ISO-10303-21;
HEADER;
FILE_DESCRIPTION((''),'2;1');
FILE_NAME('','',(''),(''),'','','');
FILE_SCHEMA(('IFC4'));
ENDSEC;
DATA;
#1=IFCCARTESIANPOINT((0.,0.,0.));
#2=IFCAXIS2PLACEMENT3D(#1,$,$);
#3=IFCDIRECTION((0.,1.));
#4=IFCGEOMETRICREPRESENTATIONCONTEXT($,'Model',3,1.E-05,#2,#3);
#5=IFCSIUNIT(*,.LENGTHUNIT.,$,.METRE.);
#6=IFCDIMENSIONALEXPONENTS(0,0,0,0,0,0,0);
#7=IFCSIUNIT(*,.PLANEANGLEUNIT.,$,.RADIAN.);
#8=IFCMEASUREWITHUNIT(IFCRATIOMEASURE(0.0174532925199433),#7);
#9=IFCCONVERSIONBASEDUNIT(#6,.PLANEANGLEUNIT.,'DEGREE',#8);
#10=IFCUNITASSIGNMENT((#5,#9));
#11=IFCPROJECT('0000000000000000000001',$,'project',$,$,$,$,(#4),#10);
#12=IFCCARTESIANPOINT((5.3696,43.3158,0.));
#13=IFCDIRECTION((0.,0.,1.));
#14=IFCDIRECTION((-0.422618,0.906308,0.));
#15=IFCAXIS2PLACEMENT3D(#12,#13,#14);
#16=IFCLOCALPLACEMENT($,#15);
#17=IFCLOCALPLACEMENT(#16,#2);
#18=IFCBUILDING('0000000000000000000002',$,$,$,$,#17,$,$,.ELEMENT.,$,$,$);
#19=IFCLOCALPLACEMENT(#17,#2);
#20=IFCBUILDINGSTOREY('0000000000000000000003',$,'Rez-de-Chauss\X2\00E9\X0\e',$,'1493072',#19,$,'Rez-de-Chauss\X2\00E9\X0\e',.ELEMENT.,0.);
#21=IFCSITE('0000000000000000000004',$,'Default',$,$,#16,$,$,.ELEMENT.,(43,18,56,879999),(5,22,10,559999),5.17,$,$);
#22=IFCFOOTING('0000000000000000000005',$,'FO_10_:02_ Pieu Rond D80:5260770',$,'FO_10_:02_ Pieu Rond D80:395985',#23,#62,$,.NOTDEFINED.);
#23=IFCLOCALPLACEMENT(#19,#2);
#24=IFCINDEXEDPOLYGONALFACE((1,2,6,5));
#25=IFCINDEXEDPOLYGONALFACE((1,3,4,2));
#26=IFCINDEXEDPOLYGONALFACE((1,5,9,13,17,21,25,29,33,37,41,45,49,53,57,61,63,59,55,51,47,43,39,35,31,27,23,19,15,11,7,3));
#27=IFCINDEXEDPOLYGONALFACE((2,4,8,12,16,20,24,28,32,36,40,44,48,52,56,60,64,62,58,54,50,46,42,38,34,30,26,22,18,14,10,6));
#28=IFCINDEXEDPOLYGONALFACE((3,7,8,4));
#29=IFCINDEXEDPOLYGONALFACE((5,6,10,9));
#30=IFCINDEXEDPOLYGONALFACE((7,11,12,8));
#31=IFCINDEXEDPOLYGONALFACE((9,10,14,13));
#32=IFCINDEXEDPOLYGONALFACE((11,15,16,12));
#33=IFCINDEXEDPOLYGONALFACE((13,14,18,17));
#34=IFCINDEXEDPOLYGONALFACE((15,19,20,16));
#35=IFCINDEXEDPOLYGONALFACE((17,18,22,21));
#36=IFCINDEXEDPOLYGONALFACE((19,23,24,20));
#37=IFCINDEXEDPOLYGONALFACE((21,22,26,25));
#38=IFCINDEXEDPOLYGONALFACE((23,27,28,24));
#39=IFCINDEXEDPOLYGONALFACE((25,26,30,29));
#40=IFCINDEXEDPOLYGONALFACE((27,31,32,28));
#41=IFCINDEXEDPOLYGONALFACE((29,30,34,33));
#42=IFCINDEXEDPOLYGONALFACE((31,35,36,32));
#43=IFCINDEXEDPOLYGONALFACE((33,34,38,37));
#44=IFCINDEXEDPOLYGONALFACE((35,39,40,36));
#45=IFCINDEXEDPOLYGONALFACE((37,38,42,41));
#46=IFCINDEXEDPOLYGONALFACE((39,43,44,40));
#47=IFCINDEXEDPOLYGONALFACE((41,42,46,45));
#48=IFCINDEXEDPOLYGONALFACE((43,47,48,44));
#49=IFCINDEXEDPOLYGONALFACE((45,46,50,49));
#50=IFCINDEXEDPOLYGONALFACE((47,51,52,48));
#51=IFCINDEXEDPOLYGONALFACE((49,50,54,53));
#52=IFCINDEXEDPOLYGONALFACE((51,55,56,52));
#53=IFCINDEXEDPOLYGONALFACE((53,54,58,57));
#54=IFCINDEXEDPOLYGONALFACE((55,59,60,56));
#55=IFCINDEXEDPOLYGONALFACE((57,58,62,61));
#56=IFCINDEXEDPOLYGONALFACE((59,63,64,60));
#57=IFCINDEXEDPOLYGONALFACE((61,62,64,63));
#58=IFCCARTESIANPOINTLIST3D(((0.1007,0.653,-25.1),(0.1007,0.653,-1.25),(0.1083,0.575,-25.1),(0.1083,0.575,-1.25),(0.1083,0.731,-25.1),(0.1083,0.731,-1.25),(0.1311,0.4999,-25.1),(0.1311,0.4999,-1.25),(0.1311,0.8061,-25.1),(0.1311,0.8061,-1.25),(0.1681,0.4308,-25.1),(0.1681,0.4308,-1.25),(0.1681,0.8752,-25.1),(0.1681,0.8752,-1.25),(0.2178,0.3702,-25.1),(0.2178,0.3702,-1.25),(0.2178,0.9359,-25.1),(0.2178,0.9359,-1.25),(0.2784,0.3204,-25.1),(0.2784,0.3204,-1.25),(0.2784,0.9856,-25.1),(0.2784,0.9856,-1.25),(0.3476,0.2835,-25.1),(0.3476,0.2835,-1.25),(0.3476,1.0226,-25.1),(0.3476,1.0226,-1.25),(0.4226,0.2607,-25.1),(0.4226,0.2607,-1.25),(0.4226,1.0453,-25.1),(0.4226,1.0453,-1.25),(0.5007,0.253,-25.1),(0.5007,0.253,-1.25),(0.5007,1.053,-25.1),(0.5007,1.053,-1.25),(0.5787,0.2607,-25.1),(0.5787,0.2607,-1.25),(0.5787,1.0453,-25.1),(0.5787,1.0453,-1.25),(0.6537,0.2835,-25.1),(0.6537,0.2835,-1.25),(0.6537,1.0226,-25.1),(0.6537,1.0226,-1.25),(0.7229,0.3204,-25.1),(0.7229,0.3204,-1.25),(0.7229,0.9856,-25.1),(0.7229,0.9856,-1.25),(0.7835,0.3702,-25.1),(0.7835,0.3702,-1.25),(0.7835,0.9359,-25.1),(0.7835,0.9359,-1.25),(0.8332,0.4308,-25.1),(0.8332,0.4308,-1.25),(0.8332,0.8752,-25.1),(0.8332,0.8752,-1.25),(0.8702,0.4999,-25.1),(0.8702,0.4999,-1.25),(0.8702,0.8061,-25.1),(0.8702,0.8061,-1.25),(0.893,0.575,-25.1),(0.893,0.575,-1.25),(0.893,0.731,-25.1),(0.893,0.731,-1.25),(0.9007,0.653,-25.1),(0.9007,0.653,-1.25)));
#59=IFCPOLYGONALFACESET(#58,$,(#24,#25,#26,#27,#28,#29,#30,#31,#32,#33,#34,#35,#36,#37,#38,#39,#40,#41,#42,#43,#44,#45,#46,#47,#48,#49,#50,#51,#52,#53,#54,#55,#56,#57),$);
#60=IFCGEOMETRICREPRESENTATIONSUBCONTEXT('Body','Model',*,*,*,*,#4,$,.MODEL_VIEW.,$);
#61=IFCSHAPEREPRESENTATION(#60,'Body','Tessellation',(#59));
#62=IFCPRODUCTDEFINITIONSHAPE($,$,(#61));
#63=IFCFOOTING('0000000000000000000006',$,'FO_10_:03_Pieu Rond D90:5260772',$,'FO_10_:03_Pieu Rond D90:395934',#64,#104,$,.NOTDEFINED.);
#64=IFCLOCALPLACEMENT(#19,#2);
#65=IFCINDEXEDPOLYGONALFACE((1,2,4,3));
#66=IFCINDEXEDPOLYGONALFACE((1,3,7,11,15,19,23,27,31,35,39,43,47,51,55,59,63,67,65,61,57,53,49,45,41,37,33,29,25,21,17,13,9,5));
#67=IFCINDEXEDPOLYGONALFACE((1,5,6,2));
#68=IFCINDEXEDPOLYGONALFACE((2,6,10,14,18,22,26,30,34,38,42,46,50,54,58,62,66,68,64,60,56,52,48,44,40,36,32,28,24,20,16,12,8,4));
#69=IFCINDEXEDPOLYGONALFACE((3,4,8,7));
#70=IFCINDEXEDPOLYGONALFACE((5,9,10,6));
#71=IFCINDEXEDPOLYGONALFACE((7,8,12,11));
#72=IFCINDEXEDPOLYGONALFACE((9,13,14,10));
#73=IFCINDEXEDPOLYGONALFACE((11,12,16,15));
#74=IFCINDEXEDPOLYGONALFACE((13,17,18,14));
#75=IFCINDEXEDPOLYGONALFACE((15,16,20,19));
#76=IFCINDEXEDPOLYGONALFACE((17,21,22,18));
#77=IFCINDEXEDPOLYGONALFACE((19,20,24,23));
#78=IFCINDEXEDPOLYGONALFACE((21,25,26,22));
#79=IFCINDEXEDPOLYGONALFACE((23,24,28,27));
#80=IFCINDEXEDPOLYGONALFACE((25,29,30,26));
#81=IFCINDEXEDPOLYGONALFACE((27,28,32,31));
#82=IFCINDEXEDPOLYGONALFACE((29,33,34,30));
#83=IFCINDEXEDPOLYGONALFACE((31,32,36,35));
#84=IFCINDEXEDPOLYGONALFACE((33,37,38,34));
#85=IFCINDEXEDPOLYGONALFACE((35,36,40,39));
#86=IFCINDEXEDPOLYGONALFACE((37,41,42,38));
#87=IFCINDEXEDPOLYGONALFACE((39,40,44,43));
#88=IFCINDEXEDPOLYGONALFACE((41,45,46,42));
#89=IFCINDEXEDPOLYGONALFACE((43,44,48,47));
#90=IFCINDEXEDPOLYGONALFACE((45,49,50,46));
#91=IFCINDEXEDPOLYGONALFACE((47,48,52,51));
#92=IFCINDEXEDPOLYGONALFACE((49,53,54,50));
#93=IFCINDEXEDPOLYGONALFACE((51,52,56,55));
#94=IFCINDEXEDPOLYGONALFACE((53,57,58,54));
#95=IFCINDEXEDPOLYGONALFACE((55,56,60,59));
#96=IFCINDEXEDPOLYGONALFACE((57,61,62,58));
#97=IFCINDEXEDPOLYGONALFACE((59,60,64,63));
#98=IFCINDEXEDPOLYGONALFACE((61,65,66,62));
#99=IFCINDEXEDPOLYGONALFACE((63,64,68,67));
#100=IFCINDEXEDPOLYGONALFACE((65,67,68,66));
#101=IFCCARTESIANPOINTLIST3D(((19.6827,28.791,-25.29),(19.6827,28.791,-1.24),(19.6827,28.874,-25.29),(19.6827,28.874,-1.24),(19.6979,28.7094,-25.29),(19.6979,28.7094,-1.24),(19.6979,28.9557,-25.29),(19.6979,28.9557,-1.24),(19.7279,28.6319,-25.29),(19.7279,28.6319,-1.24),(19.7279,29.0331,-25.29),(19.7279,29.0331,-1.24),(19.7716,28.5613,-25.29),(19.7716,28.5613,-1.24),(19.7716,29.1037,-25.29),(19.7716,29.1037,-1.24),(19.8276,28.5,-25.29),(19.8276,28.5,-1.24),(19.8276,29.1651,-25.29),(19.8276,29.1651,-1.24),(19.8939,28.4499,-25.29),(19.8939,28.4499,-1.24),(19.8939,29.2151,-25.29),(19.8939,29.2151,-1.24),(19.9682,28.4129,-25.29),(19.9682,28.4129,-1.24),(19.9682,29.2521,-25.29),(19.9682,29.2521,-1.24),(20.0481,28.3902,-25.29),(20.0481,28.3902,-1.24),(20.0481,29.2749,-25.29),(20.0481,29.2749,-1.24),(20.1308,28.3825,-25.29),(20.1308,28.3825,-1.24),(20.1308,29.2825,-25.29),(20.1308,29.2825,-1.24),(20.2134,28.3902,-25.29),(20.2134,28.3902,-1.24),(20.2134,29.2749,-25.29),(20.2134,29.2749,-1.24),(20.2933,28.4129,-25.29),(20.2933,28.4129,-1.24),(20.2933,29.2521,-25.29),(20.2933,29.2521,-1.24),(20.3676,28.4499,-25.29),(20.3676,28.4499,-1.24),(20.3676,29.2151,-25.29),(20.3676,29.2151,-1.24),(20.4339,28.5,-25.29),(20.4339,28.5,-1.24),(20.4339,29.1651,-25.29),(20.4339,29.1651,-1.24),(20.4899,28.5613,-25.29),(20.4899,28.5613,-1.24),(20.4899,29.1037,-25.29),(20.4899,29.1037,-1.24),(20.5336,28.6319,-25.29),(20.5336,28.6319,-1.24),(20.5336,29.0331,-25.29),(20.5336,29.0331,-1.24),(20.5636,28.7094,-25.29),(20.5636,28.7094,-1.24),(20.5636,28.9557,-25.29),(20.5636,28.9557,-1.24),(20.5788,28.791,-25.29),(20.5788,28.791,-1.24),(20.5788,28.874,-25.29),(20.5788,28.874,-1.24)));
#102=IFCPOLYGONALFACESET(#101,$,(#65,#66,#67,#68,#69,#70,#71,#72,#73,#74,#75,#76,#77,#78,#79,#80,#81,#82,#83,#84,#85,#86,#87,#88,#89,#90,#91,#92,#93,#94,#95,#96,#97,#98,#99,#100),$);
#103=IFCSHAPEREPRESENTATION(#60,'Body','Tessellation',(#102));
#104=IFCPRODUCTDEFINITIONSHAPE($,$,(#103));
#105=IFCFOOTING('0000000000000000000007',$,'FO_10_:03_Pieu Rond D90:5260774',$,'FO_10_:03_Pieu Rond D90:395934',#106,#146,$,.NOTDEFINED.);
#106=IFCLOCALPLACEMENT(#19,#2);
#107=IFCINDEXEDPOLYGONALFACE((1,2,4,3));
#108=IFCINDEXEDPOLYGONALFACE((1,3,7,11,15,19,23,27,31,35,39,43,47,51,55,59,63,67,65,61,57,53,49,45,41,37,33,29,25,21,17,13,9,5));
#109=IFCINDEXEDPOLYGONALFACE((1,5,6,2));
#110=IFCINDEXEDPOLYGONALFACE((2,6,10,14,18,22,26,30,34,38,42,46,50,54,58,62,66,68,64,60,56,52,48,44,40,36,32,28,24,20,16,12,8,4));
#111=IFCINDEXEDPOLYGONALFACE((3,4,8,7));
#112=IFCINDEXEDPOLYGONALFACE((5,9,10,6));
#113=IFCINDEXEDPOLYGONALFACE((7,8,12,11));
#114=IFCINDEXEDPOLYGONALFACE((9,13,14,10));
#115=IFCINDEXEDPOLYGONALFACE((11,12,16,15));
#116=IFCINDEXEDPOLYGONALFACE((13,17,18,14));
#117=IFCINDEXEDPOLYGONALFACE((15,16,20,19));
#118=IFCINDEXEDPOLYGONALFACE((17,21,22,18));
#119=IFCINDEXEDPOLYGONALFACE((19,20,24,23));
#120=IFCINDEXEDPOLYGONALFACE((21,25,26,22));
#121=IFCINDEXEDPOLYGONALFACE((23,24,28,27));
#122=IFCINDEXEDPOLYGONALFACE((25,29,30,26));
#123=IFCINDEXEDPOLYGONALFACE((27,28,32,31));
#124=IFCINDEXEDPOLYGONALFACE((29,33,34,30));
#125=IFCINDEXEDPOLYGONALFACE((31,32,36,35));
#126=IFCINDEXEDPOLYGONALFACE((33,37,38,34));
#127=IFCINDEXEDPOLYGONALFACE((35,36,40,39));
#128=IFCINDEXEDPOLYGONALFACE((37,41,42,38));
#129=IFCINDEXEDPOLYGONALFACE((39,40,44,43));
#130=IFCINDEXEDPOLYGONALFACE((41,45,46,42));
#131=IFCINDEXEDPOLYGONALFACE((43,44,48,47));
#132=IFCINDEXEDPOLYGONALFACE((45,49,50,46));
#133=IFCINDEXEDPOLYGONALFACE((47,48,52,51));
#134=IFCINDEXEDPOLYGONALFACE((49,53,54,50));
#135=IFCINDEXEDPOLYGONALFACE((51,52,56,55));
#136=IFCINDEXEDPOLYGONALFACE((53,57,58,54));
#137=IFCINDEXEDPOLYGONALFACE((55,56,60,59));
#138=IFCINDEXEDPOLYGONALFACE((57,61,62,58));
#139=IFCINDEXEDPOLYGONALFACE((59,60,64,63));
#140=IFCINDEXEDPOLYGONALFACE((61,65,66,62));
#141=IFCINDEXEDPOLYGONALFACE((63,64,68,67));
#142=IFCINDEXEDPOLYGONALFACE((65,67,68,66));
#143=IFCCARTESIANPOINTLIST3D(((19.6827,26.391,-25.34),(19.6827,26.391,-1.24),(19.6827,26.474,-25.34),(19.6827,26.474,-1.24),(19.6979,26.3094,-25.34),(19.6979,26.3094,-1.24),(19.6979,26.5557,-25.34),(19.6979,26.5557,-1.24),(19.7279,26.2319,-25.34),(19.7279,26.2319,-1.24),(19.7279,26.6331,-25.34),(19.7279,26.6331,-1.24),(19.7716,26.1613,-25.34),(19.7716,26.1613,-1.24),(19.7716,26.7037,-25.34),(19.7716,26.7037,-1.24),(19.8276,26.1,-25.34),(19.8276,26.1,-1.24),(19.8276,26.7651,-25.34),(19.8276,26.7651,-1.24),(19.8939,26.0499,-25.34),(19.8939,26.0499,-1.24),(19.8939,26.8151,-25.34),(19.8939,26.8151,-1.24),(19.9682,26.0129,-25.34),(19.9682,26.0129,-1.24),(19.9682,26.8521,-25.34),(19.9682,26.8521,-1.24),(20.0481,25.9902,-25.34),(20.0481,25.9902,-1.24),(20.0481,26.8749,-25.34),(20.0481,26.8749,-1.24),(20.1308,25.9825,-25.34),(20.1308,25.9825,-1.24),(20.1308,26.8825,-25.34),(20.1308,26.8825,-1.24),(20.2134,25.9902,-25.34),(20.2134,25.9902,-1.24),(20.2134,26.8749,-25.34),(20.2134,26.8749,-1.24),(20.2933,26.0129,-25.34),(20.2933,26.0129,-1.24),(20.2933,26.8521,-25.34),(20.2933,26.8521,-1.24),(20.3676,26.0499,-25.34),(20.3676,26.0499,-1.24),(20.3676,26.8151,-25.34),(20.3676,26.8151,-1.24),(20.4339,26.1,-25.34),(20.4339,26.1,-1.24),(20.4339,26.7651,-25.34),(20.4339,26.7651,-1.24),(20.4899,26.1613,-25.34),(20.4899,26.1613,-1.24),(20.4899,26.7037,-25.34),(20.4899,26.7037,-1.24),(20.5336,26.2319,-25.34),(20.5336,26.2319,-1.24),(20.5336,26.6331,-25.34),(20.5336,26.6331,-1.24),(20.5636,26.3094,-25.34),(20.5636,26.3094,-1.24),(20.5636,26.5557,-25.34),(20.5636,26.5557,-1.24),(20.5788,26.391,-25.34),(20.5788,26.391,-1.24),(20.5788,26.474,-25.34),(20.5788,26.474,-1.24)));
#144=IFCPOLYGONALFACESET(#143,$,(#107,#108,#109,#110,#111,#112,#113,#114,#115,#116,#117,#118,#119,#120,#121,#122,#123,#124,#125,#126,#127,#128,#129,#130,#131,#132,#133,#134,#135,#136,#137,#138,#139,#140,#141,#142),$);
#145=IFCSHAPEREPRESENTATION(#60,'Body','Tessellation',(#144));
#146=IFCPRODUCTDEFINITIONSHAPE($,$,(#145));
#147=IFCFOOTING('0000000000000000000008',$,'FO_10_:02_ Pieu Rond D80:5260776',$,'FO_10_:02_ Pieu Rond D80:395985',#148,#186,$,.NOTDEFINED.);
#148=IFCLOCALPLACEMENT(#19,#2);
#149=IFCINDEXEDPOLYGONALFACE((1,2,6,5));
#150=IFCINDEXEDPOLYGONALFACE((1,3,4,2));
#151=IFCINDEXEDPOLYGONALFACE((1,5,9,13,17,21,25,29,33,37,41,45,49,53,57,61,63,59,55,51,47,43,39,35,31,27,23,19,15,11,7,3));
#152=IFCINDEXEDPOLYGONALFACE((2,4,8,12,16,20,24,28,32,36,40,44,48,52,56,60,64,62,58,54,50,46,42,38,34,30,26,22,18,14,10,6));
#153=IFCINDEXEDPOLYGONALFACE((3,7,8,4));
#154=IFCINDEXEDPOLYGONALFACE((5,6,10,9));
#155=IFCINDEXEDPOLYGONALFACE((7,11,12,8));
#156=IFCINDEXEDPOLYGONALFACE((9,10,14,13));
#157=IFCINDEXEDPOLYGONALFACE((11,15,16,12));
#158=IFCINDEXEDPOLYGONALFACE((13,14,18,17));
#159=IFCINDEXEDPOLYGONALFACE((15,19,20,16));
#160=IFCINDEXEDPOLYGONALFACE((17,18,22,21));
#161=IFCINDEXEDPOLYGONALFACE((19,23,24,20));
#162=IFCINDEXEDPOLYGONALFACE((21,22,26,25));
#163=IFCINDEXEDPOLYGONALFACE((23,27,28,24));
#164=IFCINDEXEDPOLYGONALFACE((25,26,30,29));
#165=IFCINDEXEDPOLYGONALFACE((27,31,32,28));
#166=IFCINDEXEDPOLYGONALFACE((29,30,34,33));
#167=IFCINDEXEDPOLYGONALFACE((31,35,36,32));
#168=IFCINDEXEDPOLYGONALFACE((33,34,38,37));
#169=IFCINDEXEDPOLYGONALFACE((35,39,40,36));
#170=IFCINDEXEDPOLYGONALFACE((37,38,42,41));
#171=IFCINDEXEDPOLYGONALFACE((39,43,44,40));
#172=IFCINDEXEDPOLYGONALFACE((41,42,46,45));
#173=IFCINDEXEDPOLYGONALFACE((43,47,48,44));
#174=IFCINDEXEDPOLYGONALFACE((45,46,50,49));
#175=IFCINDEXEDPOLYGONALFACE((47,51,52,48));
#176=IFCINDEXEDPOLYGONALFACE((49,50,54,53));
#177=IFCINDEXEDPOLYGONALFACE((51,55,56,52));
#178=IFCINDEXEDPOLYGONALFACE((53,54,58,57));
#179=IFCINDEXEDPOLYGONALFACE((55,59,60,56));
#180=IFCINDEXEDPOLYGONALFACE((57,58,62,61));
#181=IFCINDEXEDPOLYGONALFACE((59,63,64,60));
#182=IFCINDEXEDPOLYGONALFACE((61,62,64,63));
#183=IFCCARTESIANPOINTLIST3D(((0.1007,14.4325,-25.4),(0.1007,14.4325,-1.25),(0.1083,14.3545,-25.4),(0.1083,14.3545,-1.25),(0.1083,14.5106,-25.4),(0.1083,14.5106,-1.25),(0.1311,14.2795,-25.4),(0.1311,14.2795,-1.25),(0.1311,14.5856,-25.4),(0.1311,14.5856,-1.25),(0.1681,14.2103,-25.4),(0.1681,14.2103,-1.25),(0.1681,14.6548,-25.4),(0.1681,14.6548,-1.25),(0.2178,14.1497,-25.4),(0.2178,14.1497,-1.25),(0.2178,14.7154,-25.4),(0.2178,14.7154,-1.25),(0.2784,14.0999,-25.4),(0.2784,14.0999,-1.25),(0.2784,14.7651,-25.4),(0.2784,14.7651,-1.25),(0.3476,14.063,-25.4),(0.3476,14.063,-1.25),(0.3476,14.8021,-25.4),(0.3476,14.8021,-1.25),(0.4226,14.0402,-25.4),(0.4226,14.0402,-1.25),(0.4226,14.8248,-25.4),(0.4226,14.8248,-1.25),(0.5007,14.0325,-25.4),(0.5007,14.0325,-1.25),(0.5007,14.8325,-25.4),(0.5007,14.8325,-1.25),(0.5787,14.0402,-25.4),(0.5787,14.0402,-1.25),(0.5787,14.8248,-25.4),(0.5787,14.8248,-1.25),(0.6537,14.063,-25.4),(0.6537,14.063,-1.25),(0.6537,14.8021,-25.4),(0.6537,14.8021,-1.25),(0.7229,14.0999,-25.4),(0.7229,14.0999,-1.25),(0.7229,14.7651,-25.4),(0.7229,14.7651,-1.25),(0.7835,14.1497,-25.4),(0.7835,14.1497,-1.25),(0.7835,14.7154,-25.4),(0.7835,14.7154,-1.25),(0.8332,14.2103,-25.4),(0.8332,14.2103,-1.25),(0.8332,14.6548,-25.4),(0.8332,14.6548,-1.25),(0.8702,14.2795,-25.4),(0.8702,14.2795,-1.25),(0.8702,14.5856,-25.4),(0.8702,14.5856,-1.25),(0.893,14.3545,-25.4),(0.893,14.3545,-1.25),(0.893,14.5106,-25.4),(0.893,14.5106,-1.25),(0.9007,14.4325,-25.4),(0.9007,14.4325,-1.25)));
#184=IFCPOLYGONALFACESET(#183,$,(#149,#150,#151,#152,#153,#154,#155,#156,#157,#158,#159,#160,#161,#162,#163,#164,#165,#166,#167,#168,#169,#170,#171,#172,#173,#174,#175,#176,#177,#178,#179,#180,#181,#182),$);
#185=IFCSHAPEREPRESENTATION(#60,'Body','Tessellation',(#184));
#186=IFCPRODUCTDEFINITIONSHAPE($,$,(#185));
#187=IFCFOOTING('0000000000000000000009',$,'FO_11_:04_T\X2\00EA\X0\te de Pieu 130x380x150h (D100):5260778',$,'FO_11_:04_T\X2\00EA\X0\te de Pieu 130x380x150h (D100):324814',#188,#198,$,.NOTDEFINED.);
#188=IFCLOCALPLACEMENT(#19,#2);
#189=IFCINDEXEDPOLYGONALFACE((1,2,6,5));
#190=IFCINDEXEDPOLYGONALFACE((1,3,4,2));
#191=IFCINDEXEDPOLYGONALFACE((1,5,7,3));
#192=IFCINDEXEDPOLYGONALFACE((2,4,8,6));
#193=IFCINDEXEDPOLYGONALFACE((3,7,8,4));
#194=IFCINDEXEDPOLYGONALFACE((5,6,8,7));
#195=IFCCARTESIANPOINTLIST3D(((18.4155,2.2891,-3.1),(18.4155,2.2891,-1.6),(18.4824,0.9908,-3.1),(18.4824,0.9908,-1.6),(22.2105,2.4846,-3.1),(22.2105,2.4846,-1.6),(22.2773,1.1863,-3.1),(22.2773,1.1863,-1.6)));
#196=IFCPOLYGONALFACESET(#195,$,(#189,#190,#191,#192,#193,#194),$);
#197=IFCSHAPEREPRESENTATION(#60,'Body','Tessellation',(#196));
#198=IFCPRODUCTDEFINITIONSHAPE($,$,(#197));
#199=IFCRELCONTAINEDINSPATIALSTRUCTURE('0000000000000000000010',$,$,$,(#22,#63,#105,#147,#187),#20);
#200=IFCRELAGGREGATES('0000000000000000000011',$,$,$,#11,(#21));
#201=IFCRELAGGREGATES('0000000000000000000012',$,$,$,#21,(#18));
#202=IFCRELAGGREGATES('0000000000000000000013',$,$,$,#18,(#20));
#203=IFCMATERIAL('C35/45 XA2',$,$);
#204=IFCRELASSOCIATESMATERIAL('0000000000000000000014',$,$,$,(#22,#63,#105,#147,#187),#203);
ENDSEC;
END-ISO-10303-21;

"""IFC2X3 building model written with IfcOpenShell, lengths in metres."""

from ifc_helpers import new_model, entity, si_unit, converted_unit, direction, frame, frame_2d, origin, origin_2d_with_axis, place, context, subcontext, project, spatial, rectangle, circle, extrude, material, element, save


model = new_model("IFC2X3")

# Units and contexts
model_context = context("Model", 3, precision=1e-05, world=origin(), true_north=direction((0.0, 1.0)))
body_context = subcontext(model_context, "Body", "Model", "MODEL_VIEW")
ifc_project = project(units=[si_unit("LENGTHUNIT", "METRE"), converted_unit("PLANEANGLEUNIT", "DEGREE", entity("IfcRatioMeasure", 0.0174532925199433), si_unit("PLANEANGLEUNIT", "RADIAN"), dimensions=[0, 0, 0, 0, 0, 0, 0])], contexts=[model_context])

# Site, building, storey
site_placement = place(None, frame((5.3696, 43.3158, 0.0), z_axis=(0.0, 0.0, 1.0), x_axis=(-0.422618, 0.906308, 0.0)))
site = spatial("IfcSite", under=ifc_project, at=site_placement, Name="Default", CompositionType="ELEMENT", RefLatitude=(43, 18, 56, 879999), RefLongitude=(5, 22, 10, 559999), RefElevation=5.17)
building_placement = place(site_placement, origin())
building = spatial("IfcBuilding", under=site, at=building_placement, CompositionType="ELEMENT")
storey_placement = place(building_placement, origin())
storey = spatial("IfcBuildingStorey", under=building, at=storey_placement, Name="Rez-de-Chaussée", ObjectType="1493072", LongName="Rez-de-Chaussée", CompositionType="ELEMENT", Elevation=0.0)

# Footings
ifc_material_1 = material(Name="C35/45 XA2")
footing_1_placement = place(storey_placement, origin())
element("IfcFooting", 1, at=footing_1_placement, inside=storey, material=ifc_material_1, Name="FO_10_:02_ Pieu Rond D80:5260770", ObjectType="FO_10_:02_ Pieu Rond D80:395985", PredefinedType="NOTDEFINED", context=body_context, shape_type="SweptSolid", body=[
    extrude(circle(Radius=0.4, at=frame_2d((0.0, 0.0), x_axis=(1.0, 0.0))), frame((0.5007, 0.653, -25.1), z_axis=(0.0, 0.0, 1.0), x_axis=(0.0, -1.0, 0.0)), (0.0, 0.0, 1.0), 23.85),
])
footing_2_placement = place(storey_placement, origin())
element("IfcFooting", 2, at=footing_2_placement, inside=storey, material=ifc_material_1, Name="FO_10_:03_Pieu Rond D90:5260772", ObjectType="FO_10_:03_Pieu Rond D90:395934", PredefinedType="NOTDEFINED", context=body_context, shape_type="SweptSolid", body=[
    extrude(circle(Radius=0.45, at=origin_2d_with_axis()), frame((20.1308, 28.8325, -25.29), z_axis=(0.0, 0.0, 1.0), x_axis=(0.0, -1.0, 0.0)), (0.0, 0.0, 1.0), 24.05),
])
footing_3_placement = place(storey_placement, origin())
element("IfcFooting", 3, at=footing_3_placement, inside=storey, material=ifc_material_1, Name="FO_10_:03_Pieu Rond D90:5260774", ObjectType="FO_10_:03_Pieu Rond D90:395934", PredefinedType="NOTDEFINED", context=body_context, shape_type="SweptSolid", body=[
    extrude(circle(Radius=0.45, at=origin_2d_with_axis()), frame((20.1308, 26.4325, -25.34), z_axis=(0.0, 0.0, 1.0), x_axis=(0.0, -1.0, 0.0)), (0.0, 0.0, 1.0), 24.1),
])
footing_4_placement = place(storey_placement, origin())
element("IfcFooting", 4, at=footing_4_placement, inside=storey, material=ifc_material_1, Name="FO_10_:02_ Pieu Rond D80:5260776", ObjectType="FO_10_:02_ Pieu Rond D80:395985", PredefinedType="NOTDEFINED", context=body_context, shape_type="SweptSolid", body=[
    extrude(circle(Radius=0.4, at=frame_2d((0.0, 0.0), x_axis=(1.0, 0.0))), frame((0.5007, 14.4325, -25.4), z_axis=(0.0, 0.0, 1.0), x_axis=(0.0, -1.0, 0.0)), (0.0, 0.0, 1.0), 24.15),
])
footing_5_placement = place(storey_placement, origin())
element("IfcFooting", 5, at=footing_5_placement, inside=storey, material=ifc_material_1, Name="FO_11_:04_Tête de Pieu 130x380x150h (D100):5260778", ObjectType="FO_11_:04_Tête de Pieu 130x380x150h (D100):324814", PredefinedType="NOTDEFINED", context=body_context, shape_type="SweptSolid", body=[
    extrude(rectangle(XDim=3.8, YDim=1.3, at=frame_2d((0.0, 0.0), x_axis=(1.0, 0.0))), frame((20.3464, 1.7377, -3.1), z_axis=(0.0, 0.0, 1.0), x_axis=(0.998676, 0.051439, 0.0)), (0.0, 0.0, 1.0), 1.5),
])

save(model, "model.ifc")
